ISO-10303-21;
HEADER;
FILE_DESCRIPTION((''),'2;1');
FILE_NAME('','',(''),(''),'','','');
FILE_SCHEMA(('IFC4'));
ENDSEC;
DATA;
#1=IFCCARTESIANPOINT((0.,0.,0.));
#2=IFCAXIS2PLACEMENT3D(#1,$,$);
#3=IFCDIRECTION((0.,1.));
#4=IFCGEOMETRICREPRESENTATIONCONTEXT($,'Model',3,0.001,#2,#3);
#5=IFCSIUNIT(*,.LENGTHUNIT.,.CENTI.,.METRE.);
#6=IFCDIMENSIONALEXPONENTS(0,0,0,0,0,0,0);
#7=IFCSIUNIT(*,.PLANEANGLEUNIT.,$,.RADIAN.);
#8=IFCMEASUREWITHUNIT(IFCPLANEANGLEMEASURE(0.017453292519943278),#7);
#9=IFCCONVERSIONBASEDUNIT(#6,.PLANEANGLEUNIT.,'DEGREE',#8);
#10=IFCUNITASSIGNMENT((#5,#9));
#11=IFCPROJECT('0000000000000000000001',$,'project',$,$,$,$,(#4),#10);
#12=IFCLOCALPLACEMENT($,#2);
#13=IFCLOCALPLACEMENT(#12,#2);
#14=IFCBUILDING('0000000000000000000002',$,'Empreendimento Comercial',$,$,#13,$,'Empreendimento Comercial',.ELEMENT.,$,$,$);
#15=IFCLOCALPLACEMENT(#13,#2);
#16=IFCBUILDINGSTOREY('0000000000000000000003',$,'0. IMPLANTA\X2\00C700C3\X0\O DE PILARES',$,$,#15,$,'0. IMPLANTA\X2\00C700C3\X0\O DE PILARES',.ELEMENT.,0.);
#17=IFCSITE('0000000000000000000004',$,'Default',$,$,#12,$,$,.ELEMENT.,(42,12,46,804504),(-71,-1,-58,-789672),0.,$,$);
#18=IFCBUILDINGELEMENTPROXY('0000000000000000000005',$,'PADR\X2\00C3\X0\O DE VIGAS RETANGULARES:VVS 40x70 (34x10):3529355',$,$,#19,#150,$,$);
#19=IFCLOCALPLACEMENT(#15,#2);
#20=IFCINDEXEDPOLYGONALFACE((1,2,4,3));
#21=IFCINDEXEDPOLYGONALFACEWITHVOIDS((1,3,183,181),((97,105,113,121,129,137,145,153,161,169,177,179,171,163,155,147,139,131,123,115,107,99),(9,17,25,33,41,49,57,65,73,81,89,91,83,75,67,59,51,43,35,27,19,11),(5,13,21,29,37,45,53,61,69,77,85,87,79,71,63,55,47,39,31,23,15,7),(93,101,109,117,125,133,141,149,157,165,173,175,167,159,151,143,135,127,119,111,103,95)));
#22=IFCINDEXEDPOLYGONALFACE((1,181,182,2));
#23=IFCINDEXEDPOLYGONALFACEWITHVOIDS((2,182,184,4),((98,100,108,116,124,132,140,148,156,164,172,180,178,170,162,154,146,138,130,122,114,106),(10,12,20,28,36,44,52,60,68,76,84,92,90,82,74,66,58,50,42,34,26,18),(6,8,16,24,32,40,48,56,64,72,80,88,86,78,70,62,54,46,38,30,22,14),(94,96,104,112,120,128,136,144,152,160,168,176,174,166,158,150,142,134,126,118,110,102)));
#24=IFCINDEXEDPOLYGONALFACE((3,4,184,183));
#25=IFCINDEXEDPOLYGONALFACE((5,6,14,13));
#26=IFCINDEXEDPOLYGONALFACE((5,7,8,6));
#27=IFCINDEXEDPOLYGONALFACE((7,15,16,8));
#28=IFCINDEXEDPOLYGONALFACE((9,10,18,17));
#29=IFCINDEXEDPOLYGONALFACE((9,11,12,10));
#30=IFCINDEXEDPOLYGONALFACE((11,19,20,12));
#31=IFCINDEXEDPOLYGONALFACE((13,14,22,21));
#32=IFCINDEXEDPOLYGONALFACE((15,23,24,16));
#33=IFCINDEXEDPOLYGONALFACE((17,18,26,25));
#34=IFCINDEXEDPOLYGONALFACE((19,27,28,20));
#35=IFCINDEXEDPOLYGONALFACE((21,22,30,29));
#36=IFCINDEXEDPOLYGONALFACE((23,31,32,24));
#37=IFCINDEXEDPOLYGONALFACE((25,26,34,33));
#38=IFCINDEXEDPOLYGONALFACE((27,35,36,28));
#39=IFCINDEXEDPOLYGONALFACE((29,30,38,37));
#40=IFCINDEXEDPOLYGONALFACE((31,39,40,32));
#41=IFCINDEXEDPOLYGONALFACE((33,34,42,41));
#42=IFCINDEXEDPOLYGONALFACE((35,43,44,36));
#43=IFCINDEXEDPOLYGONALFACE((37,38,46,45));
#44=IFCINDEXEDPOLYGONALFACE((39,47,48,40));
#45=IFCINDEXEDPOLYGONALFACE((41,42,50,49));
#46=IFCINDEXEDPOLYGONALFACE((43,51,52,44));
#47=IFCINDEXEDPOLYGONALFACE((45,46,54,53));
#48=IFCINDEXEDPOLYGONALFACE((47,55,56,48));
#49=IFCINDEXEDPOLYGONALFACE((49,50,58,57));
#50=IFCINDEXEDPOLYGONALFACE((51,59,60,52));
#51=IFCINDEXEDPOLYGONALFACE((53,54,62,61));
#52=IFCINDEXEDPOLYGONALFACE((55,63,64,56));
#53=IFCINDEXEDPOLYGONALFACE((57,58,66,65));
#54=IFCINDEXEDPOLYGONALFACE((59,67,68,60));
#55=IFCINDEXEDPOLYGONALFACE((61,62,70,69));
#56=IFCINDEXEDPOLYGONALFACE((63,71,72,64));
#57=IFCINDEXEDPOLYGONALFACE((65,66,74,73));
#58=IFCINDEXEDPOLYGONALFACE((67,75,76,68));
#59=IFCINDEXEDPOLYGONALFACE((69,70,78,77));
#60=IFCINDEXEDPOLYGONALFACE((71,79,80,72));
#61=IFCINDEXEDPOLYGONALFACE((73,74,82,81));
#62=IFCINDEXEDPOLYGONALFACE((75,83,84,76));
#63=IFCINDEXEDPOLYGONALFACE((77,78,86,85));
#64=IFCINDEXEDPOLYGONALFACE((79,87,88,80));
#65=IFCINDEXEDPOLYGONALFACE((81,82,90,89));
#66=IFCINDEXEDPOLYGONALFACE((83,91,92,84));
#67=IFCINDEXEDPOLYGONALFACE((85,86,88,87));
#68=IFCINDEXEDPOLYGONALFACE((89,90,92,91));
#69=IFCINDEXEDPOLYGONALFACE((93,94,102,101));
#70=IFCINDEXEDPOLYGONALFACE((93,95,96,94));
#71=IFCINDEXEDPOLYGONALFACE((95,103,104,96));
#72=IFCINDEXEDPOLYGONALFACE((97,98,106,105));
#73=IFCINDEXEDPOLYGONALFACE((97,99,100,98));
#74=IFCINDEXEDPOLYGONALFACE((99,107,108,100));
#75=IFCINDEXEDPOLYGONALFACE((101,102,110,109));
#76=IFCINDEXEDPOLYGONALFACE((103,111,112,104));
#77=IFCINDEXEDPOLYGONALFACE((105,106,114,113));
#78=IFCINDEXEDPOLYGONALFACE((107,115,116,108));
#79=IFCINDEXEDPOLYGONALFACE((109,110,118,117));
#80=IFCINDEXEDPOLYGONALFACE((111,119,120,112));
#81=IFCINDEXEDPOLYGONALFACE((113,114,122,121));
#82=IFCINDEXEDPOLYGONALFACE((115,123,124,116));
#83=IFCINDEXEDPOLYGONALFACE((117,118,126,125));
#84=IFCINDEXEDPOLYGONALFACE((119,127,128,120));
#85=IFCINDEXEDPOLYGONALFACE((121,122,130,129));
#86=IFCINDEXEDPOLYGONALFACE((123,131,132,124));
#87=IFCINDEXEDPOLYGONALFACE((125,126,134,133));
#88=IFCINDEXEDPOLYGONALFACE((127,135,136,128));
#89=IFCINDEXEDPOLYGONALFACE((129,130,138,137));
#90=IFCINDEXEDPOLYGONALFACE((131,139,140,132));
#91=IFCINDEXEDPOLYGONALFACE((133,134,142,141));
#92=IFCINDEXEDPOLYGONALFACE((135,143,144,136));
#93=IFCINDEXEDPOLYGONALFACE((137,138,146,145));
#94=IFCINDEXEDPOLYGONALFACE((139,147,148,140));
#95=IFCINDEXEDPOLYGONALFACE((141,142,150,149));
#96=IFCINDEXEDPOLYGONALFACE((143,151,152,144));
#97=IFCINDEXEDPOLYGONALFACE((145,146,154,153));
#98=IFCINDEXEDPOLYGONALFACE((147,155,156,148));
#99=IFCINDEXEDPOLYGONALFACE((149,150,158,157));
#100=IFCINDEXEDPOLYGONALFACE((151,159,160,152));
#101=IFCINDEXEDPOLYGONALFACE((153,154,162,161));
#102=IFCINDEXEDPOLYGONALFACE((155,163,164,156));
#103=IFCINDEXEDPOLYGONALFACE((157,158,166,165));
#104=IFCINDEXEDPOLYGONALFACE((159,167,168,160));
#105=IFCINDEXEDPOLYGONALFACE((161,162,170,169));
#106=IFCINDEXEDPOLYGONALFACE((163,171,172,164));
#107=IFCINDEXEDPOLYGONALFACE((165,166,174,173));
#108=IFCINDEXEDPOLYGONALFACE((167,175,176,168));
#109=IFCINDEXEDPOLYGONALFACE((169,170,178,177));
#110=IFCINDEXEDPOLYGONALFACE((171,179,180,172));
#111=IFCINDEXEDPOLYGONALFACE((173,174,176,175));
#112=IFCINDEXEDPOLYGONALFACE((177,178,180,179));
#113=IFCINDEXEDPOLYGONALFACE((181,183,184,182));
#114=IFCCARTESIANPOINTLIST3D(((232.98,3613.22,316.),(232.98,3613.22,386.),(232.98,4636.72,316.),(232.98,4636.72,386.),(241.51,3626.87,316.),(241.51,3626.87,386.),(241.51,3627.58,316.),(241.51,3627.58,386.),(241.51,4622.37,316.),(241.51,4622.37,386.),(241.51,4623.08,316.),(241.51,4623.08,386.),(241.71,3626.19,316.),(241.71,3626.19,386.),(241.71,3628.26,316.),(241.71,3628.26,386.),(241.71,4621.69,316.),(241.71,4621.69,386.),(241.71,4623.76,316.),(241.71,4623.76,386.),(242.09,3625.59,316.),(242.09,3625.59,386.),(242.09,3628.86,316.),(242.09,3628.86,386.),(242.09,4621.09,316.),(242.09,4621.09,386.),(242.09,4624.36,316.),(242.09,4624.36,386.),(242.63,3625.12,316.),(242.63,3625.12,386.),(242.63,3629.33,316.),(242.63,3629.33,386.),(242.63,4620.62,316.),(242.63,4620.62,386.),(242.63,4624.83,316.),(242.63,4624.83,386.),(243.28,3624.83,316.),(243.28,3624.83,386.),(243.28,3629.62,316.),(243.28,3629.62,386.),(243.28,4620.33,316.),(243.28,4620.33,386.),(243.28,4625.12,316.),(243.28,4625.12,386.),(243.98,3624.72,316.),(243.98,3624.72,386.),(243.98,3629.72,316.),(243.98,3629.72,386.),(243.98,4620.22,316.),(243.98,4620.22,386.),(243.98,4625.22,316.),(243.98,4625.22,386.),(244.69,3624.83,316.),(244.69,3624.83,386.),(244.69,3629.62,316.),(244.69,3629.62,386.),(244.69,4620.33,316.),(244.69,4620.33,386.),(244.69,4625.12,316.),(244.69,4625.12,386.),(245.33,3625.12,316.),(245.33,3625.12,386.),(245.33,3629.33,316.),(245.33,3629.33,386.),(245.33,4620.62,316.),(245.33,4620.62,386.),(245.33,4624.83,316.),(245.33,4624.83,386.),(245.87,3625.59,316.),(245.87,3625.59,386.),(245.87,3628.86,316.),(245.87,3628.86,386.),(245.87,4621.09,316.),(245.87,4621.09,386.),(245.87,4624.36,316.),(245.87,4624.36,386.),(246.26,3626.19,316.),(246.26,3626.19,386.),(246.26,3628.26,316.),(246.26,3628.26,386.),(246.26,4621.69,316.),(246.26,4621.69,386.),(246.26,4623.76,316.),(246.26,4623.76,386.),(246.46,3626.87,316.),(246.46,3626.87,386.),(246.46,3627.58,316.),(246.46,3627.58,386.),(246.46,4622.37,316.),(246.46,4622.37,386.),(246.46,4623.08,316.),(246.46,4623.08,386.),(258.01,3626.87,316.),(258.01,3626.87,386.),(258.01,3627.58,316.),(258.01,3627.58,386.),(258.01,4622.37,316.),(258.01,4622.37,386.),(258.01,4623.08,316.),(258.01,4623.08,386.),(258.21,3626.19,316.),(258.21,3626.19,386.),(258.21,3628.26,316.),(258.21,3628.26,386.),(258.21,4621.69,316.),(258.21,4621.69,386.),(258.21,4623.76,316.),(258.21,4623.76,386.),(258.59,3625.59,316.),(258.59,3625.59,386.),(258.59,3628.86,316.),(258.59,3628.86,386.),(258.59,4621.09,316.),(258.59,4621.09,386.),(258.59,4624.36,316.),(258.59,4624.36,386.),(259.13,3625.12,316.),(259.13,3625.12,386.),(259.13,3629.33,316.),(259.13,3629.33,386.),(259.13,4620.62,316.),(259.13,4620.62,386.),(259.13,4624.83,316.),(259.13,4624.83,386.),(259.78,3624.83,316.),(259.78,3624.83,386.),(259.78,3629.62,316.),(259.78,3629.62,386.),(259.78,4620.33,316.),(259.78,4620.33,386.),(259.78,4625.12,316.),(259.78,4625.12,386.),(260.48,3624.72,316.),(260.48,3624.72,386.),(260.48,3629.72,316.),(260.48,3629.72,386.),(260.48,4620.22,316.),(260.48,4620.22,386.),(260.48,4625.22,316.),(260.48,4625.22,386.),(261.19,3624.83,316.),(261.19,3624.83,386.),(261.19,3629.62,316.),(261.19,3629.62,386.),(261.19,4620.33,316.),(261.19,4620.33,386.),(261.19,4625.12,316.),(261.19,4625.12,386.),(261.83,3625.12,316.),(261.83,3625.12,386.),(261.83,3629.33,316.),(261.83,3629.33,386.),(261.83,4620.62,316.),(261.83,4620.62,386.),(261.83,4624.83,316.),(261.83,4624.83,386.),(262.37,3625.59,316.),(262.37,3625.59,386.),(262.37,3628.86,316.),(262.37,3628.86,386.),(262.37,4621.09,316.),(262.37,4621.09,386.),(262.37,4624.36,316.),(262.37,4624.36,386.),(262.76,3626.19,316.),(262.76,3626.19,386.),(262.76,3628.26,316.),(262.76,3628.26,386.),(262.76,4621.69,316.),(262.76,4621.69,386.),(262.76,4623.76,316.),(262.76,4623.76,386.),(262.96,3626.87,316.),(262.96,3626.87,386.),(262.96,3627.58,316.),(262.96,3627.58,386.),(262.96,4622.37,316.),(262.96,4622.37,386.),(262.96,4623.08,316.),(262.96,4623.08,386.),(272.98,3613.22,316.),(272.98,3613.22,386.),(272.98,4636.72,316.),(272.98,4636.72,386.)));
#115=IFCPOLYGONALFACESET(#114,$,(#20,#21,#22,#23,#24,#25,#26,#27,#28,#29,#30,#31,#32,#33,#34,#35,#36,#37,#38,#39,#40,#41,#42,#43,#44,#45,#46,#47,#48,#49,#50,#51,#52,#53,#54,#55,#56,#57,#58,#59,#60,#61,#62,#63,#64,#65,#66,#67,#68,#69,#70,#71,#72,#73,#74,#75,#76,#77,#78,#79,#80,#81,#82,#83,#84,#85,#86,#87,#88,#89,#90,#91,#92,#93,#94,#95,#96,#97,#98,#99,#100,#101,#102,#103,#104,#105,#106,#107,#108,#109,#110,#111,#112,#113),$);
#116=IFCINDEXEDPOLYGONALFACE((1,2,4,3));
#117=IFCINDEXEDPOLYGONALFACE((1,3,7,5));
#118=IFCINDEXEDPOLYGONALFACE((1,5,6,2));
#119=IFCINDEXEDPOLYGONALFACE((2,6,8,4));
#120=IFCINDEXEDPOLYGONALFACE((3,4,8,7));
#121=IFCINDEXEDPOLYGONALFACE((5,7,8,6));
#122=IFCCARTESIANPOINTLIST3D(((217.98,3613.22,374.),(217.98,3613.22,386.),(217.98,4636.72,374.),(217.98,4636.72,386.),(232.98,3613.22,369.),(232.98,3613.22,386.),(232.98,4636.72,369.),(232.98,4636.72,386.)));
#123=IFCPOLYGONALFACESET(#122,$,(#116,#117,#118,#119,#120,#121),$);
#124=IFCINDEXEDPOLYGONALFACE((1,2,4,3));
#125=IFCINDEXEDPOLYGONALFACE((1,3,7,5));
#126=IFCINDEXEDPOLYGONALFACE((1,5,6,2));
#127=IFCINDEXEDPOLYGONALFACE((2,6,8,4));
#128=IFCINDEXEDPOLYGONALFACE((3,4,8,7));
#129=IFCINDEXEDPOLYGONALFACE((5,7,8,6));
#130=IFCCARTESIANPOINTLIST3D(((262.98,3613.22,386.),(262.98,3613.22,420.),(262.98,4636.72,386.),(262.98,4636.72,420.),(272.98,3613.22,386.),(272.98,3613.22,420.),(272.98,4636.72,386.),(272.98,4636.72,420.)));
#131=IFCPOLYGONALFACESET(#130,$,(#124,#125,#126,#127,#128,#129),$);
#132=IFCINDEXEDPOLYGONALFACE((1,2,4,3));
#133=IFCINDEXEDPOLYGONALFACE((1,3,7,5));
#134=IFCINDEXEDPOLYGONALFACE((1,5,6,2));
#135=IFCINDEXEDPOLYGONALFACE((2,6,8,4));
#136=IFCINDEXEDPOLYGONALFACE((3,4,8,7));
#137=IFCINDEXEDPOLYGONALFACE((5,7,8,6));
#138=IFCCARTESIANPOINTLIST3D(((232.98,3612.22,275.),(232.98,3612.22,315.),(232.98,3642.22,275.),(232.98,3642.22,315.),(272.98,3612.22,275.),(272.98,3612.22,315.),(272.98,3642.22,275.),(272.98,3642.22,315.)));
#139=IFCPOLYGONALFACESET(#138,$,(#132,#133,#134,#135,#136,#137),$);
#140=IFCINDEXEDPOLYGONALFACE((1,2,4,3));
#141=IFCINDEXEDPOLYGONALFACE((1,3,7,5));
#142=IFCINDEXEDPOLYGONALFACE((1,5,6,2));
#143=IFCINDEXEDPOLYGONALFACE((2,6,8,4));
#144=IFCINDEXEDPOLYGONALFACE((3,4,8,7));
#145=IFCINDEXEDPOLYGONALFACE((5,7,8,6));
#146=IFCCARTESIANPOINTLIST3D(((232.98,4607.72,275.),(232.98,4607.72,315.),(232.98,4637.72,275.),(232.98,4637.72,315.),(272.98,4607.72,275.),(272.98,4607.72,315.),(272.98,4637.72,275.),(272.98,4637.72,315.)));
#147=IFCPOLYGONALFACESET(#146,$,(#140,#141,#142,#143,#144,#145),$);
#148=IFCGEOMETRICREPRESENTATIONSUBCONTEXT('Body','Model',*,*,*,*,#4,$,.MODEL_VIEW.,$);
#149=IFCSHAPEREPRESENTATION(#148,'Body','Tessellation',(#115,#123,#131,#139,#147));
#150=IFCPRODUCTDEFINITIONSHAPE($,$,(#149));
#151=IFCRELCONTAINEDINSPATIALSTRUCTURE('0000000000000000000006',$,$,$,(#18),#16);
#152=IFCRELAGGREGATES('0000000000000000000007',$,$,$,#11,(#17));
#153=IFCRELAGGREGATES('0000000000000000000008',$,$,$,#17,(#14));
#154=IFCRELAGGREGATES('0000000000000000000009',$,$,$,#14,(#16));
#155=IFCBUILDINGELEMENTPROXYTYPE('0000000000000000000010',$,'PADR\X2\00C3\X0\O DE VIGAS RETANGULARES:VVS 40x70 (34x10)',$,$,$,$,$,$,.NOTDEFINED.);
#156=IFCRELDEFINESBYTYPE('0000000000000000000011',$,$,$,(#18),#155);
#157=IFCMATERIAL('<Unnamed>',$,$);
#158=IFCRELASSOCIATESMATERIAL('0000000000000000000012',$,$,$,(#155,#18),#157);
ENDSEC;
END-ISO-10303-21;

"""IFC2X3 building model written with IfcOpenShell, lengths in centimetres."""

from ifc_helpers import new_model, entity, si_unit, converted_unit, direction, frame, frame_2d, origin, place, context, subcontext, project, spatial, polyline, circle_curve, parameter, trimmed, segment, composite_curve, rectangle, outline, extrude, source, transform, mapped, material, type_object, type_shapes, element, save


model = new_model("IFC2X3")

# Units and contexts
model_context = context("Model", 3, precision=0.001, world=origin(), true_north=direction((0.0, 1.0)))
body_context = subcontext(model_context, "Body", "Model", "MODEL_VIEW")
ifc_project = project(units=[si_unit("LENGTHUNIT", "METRE", prefix="CENTI"), converted_unit("PLANEANGLEUNIT", "DEGREE", entity("IfcPlaneAngleMeasure", 0.017453292519943278), si_unit("PLANEANGLEUNIT", "RADIAN"), dimensions=[0, 0, 0, 0, 0, 0, 0])], contexts=[model_context])

# Site, building, storey
site_placement = place(None, origin())
site = spatial("IfcSite", under=ifc_project, at=site_placement, Name="Default", CompositionType="ELEMENT", RefLatitude=(42, 12, 46, 804504), RefLongitude=(-71, -1, -58, -789672), RefElevation=0.0)
building_placement = place(site_placement, origin())
building = spatial("IfcBuilding", under=site, at=building_placement, Name="Empreendimento Comercial", LongName="Empreendimento Comercial", CompositionType="ELEMENT")
storey_placement = place(building_placement, origin())
storey = spatial("IfcBuildingStorey", under=building, at=storey_placement, Name="0. IMPLANTAÇÃO DE PILARES", LongName="0. IMPLANTAÇÃO DE PILARES", CompositionType="ELEMENT", Elevation=0.0)

# Building element proxy
ifc_material_1 = material(Name="<Unnamed>")
building_element_proxy_type_1 = type_object("IfcBuildingElementProxyType", Name="PADRÃO DE VIGAS RETANGULARES:VVS 40x70 (34x10)", PredefinedType="NOTDEFINED", material=ifc_material_1)
shared_shape_1 = source(origin(), body_context, "Body", "SweptSolid", [
    extrude(outline(polyline([(-20.0, -511.75), (20.0, -511.75), (20.0, 511.75), (-20.0, 511.75), (-20.0, -511.75)]), holes=[composite_curve([segment(trimmed(circle_curve(frame_2d((9.0, 497.75), x_axis=(0.0, -1.0)), 2.5), [parameter(0.0)], [parameter(180.0)], True, "PARAMETER"), False, "CONTINUOUS"), segment(trimmed(circle_curve(frame_2d((9.0, 497.75), x_axis=(0.0, -1.0)), 2.5), [parameter(180.0)], [parameter(0.0)], True, "PARAMETER"), False, "CONTINUOUS")], self_intersect=False), composite_curve([segment(trimmed(circle_curve(frame_2d((-7.5, 497.75), x_axis=(0.0, -1.0)), 2.5), [parameter(0.0)], [parameter(180.0)], True, "PARAMETER"), False, "CONTINUOUS"), segment(trimmed(circle_curve(frame_2d((-7.5, 497.75), x_axis=(0.0, -1.0)), 2.5), [parameter(180.0)], [parameter(0.0)], True, "PARAMETER"), False, "CONTINUOUS")], self_intersect=False), composite_curve([segment(trimmed(circle_curve(frame_2d((-7.5, -497.75), x_axis=(0.0, -1.0)), 2.5), [parameter(0.0)], [parameter(180.0)], True, "PARAMETER"), False, "CONTINUOUS"), segment(trimmed(circle_curve(frame_2d((-7.5, -497.75), x_axis=(0.0, -1.0)), 2.5), [parameter(180.0)], [parameter(0.0)], True, "PARAMETER"), False, "CONTINUOUS")], self_intersect=False), composite_curve([segment(trimmed(circle_curve(frame_2d((9.0, -497.75), x_axis=(0.0, -1.0)), 2.5), [parameter(0.0)], [parameter(180.0)], True, "PARAMETER"), False, "CONTINUOUS"), segment(trimmed(circle_curve(frame_2d((9.0, -497.75), x_axis=(0.0, -1.0)), 2.5), [parameter(180.0)], [parameter(0.0)], True, "PARAMETER"), False, "CONTINUOUS")], self_intersect=False)]), frame((252.98, 4124.97, 316.0), z_axis=(0.0, 0.0, 1.0), x_axis=(-1.0, 0.0, 0.0)), (0.0, 0.0, 1.0), 70.0),
    extrude(outline(polyline([(-7.5, -7.25), (7.5, -7.25), (7.5, 9.75), (-7.5, 4.75), (-7.5, -7.25)])), frame((225.48, 3613.22, 378.75), z_axis=(0.0, 1.0, 0.0), x_axis=(1.0, 0.0, 0.0)), (0.0, 0.0, 1.0), 1023.5),
    extrude(rectangle(XDim=10.0, YDim=1023.5, at=frame_2d((0.0, 0.0), x_axis=(1.0, 0.0))), frame((267.98, 4124.97, 386.0), z_axis=(0.0, 0.0, 1.0), x_axis=(-1.0, 0.0, 0.0)), (0.0, 0.0, 1.0), 34.0),
    extrude(rectangle(XDim=30.0, YDim=40.0, at=frame_2d((0.0, 0.0), x_axis=(1.0, 0.0))), frame((252.98, 3627.22, 275.0), z_axis=(0.0, 0.0, 1.0), x_axis=(0.0, -1.0, 0.0)), (0.0, 0.0, 1.0), 40.0),
    extrude(rectangle(XDim=30.0, YDim=40.0, at=frame_2d((0.0, 0.0), x_axis=(1.0, 0.0))), frame((252.98, 4622.72, 275.0), z_axis=(0.0, 0.0, 1.0), x_axis=(0.0, -1.0, 0.0)), (0.0, 0.0, 1.0), 40.0),
])
type_shapes(building_element_proxy_type_1, [shared_shape_1])
proxy_1_placement = place(storey_placement, origin())
element("IfcBuildingElementProxy", 1, at=proxy_1_placement, inside=storey, type_object=building_element_proxy_type_1, material=ifc_material_1, Name="PADRÃO DE VIGAS RETANGULARES:VVS 40x70 (34x10):3529355", context=body_context, shape_type="MappedRepresentation", body=[
    mapped(shared_shape_1, transform((0.0, 0.0, 0.0), scale=1.0)),
])

save(model, "model.ifc")
